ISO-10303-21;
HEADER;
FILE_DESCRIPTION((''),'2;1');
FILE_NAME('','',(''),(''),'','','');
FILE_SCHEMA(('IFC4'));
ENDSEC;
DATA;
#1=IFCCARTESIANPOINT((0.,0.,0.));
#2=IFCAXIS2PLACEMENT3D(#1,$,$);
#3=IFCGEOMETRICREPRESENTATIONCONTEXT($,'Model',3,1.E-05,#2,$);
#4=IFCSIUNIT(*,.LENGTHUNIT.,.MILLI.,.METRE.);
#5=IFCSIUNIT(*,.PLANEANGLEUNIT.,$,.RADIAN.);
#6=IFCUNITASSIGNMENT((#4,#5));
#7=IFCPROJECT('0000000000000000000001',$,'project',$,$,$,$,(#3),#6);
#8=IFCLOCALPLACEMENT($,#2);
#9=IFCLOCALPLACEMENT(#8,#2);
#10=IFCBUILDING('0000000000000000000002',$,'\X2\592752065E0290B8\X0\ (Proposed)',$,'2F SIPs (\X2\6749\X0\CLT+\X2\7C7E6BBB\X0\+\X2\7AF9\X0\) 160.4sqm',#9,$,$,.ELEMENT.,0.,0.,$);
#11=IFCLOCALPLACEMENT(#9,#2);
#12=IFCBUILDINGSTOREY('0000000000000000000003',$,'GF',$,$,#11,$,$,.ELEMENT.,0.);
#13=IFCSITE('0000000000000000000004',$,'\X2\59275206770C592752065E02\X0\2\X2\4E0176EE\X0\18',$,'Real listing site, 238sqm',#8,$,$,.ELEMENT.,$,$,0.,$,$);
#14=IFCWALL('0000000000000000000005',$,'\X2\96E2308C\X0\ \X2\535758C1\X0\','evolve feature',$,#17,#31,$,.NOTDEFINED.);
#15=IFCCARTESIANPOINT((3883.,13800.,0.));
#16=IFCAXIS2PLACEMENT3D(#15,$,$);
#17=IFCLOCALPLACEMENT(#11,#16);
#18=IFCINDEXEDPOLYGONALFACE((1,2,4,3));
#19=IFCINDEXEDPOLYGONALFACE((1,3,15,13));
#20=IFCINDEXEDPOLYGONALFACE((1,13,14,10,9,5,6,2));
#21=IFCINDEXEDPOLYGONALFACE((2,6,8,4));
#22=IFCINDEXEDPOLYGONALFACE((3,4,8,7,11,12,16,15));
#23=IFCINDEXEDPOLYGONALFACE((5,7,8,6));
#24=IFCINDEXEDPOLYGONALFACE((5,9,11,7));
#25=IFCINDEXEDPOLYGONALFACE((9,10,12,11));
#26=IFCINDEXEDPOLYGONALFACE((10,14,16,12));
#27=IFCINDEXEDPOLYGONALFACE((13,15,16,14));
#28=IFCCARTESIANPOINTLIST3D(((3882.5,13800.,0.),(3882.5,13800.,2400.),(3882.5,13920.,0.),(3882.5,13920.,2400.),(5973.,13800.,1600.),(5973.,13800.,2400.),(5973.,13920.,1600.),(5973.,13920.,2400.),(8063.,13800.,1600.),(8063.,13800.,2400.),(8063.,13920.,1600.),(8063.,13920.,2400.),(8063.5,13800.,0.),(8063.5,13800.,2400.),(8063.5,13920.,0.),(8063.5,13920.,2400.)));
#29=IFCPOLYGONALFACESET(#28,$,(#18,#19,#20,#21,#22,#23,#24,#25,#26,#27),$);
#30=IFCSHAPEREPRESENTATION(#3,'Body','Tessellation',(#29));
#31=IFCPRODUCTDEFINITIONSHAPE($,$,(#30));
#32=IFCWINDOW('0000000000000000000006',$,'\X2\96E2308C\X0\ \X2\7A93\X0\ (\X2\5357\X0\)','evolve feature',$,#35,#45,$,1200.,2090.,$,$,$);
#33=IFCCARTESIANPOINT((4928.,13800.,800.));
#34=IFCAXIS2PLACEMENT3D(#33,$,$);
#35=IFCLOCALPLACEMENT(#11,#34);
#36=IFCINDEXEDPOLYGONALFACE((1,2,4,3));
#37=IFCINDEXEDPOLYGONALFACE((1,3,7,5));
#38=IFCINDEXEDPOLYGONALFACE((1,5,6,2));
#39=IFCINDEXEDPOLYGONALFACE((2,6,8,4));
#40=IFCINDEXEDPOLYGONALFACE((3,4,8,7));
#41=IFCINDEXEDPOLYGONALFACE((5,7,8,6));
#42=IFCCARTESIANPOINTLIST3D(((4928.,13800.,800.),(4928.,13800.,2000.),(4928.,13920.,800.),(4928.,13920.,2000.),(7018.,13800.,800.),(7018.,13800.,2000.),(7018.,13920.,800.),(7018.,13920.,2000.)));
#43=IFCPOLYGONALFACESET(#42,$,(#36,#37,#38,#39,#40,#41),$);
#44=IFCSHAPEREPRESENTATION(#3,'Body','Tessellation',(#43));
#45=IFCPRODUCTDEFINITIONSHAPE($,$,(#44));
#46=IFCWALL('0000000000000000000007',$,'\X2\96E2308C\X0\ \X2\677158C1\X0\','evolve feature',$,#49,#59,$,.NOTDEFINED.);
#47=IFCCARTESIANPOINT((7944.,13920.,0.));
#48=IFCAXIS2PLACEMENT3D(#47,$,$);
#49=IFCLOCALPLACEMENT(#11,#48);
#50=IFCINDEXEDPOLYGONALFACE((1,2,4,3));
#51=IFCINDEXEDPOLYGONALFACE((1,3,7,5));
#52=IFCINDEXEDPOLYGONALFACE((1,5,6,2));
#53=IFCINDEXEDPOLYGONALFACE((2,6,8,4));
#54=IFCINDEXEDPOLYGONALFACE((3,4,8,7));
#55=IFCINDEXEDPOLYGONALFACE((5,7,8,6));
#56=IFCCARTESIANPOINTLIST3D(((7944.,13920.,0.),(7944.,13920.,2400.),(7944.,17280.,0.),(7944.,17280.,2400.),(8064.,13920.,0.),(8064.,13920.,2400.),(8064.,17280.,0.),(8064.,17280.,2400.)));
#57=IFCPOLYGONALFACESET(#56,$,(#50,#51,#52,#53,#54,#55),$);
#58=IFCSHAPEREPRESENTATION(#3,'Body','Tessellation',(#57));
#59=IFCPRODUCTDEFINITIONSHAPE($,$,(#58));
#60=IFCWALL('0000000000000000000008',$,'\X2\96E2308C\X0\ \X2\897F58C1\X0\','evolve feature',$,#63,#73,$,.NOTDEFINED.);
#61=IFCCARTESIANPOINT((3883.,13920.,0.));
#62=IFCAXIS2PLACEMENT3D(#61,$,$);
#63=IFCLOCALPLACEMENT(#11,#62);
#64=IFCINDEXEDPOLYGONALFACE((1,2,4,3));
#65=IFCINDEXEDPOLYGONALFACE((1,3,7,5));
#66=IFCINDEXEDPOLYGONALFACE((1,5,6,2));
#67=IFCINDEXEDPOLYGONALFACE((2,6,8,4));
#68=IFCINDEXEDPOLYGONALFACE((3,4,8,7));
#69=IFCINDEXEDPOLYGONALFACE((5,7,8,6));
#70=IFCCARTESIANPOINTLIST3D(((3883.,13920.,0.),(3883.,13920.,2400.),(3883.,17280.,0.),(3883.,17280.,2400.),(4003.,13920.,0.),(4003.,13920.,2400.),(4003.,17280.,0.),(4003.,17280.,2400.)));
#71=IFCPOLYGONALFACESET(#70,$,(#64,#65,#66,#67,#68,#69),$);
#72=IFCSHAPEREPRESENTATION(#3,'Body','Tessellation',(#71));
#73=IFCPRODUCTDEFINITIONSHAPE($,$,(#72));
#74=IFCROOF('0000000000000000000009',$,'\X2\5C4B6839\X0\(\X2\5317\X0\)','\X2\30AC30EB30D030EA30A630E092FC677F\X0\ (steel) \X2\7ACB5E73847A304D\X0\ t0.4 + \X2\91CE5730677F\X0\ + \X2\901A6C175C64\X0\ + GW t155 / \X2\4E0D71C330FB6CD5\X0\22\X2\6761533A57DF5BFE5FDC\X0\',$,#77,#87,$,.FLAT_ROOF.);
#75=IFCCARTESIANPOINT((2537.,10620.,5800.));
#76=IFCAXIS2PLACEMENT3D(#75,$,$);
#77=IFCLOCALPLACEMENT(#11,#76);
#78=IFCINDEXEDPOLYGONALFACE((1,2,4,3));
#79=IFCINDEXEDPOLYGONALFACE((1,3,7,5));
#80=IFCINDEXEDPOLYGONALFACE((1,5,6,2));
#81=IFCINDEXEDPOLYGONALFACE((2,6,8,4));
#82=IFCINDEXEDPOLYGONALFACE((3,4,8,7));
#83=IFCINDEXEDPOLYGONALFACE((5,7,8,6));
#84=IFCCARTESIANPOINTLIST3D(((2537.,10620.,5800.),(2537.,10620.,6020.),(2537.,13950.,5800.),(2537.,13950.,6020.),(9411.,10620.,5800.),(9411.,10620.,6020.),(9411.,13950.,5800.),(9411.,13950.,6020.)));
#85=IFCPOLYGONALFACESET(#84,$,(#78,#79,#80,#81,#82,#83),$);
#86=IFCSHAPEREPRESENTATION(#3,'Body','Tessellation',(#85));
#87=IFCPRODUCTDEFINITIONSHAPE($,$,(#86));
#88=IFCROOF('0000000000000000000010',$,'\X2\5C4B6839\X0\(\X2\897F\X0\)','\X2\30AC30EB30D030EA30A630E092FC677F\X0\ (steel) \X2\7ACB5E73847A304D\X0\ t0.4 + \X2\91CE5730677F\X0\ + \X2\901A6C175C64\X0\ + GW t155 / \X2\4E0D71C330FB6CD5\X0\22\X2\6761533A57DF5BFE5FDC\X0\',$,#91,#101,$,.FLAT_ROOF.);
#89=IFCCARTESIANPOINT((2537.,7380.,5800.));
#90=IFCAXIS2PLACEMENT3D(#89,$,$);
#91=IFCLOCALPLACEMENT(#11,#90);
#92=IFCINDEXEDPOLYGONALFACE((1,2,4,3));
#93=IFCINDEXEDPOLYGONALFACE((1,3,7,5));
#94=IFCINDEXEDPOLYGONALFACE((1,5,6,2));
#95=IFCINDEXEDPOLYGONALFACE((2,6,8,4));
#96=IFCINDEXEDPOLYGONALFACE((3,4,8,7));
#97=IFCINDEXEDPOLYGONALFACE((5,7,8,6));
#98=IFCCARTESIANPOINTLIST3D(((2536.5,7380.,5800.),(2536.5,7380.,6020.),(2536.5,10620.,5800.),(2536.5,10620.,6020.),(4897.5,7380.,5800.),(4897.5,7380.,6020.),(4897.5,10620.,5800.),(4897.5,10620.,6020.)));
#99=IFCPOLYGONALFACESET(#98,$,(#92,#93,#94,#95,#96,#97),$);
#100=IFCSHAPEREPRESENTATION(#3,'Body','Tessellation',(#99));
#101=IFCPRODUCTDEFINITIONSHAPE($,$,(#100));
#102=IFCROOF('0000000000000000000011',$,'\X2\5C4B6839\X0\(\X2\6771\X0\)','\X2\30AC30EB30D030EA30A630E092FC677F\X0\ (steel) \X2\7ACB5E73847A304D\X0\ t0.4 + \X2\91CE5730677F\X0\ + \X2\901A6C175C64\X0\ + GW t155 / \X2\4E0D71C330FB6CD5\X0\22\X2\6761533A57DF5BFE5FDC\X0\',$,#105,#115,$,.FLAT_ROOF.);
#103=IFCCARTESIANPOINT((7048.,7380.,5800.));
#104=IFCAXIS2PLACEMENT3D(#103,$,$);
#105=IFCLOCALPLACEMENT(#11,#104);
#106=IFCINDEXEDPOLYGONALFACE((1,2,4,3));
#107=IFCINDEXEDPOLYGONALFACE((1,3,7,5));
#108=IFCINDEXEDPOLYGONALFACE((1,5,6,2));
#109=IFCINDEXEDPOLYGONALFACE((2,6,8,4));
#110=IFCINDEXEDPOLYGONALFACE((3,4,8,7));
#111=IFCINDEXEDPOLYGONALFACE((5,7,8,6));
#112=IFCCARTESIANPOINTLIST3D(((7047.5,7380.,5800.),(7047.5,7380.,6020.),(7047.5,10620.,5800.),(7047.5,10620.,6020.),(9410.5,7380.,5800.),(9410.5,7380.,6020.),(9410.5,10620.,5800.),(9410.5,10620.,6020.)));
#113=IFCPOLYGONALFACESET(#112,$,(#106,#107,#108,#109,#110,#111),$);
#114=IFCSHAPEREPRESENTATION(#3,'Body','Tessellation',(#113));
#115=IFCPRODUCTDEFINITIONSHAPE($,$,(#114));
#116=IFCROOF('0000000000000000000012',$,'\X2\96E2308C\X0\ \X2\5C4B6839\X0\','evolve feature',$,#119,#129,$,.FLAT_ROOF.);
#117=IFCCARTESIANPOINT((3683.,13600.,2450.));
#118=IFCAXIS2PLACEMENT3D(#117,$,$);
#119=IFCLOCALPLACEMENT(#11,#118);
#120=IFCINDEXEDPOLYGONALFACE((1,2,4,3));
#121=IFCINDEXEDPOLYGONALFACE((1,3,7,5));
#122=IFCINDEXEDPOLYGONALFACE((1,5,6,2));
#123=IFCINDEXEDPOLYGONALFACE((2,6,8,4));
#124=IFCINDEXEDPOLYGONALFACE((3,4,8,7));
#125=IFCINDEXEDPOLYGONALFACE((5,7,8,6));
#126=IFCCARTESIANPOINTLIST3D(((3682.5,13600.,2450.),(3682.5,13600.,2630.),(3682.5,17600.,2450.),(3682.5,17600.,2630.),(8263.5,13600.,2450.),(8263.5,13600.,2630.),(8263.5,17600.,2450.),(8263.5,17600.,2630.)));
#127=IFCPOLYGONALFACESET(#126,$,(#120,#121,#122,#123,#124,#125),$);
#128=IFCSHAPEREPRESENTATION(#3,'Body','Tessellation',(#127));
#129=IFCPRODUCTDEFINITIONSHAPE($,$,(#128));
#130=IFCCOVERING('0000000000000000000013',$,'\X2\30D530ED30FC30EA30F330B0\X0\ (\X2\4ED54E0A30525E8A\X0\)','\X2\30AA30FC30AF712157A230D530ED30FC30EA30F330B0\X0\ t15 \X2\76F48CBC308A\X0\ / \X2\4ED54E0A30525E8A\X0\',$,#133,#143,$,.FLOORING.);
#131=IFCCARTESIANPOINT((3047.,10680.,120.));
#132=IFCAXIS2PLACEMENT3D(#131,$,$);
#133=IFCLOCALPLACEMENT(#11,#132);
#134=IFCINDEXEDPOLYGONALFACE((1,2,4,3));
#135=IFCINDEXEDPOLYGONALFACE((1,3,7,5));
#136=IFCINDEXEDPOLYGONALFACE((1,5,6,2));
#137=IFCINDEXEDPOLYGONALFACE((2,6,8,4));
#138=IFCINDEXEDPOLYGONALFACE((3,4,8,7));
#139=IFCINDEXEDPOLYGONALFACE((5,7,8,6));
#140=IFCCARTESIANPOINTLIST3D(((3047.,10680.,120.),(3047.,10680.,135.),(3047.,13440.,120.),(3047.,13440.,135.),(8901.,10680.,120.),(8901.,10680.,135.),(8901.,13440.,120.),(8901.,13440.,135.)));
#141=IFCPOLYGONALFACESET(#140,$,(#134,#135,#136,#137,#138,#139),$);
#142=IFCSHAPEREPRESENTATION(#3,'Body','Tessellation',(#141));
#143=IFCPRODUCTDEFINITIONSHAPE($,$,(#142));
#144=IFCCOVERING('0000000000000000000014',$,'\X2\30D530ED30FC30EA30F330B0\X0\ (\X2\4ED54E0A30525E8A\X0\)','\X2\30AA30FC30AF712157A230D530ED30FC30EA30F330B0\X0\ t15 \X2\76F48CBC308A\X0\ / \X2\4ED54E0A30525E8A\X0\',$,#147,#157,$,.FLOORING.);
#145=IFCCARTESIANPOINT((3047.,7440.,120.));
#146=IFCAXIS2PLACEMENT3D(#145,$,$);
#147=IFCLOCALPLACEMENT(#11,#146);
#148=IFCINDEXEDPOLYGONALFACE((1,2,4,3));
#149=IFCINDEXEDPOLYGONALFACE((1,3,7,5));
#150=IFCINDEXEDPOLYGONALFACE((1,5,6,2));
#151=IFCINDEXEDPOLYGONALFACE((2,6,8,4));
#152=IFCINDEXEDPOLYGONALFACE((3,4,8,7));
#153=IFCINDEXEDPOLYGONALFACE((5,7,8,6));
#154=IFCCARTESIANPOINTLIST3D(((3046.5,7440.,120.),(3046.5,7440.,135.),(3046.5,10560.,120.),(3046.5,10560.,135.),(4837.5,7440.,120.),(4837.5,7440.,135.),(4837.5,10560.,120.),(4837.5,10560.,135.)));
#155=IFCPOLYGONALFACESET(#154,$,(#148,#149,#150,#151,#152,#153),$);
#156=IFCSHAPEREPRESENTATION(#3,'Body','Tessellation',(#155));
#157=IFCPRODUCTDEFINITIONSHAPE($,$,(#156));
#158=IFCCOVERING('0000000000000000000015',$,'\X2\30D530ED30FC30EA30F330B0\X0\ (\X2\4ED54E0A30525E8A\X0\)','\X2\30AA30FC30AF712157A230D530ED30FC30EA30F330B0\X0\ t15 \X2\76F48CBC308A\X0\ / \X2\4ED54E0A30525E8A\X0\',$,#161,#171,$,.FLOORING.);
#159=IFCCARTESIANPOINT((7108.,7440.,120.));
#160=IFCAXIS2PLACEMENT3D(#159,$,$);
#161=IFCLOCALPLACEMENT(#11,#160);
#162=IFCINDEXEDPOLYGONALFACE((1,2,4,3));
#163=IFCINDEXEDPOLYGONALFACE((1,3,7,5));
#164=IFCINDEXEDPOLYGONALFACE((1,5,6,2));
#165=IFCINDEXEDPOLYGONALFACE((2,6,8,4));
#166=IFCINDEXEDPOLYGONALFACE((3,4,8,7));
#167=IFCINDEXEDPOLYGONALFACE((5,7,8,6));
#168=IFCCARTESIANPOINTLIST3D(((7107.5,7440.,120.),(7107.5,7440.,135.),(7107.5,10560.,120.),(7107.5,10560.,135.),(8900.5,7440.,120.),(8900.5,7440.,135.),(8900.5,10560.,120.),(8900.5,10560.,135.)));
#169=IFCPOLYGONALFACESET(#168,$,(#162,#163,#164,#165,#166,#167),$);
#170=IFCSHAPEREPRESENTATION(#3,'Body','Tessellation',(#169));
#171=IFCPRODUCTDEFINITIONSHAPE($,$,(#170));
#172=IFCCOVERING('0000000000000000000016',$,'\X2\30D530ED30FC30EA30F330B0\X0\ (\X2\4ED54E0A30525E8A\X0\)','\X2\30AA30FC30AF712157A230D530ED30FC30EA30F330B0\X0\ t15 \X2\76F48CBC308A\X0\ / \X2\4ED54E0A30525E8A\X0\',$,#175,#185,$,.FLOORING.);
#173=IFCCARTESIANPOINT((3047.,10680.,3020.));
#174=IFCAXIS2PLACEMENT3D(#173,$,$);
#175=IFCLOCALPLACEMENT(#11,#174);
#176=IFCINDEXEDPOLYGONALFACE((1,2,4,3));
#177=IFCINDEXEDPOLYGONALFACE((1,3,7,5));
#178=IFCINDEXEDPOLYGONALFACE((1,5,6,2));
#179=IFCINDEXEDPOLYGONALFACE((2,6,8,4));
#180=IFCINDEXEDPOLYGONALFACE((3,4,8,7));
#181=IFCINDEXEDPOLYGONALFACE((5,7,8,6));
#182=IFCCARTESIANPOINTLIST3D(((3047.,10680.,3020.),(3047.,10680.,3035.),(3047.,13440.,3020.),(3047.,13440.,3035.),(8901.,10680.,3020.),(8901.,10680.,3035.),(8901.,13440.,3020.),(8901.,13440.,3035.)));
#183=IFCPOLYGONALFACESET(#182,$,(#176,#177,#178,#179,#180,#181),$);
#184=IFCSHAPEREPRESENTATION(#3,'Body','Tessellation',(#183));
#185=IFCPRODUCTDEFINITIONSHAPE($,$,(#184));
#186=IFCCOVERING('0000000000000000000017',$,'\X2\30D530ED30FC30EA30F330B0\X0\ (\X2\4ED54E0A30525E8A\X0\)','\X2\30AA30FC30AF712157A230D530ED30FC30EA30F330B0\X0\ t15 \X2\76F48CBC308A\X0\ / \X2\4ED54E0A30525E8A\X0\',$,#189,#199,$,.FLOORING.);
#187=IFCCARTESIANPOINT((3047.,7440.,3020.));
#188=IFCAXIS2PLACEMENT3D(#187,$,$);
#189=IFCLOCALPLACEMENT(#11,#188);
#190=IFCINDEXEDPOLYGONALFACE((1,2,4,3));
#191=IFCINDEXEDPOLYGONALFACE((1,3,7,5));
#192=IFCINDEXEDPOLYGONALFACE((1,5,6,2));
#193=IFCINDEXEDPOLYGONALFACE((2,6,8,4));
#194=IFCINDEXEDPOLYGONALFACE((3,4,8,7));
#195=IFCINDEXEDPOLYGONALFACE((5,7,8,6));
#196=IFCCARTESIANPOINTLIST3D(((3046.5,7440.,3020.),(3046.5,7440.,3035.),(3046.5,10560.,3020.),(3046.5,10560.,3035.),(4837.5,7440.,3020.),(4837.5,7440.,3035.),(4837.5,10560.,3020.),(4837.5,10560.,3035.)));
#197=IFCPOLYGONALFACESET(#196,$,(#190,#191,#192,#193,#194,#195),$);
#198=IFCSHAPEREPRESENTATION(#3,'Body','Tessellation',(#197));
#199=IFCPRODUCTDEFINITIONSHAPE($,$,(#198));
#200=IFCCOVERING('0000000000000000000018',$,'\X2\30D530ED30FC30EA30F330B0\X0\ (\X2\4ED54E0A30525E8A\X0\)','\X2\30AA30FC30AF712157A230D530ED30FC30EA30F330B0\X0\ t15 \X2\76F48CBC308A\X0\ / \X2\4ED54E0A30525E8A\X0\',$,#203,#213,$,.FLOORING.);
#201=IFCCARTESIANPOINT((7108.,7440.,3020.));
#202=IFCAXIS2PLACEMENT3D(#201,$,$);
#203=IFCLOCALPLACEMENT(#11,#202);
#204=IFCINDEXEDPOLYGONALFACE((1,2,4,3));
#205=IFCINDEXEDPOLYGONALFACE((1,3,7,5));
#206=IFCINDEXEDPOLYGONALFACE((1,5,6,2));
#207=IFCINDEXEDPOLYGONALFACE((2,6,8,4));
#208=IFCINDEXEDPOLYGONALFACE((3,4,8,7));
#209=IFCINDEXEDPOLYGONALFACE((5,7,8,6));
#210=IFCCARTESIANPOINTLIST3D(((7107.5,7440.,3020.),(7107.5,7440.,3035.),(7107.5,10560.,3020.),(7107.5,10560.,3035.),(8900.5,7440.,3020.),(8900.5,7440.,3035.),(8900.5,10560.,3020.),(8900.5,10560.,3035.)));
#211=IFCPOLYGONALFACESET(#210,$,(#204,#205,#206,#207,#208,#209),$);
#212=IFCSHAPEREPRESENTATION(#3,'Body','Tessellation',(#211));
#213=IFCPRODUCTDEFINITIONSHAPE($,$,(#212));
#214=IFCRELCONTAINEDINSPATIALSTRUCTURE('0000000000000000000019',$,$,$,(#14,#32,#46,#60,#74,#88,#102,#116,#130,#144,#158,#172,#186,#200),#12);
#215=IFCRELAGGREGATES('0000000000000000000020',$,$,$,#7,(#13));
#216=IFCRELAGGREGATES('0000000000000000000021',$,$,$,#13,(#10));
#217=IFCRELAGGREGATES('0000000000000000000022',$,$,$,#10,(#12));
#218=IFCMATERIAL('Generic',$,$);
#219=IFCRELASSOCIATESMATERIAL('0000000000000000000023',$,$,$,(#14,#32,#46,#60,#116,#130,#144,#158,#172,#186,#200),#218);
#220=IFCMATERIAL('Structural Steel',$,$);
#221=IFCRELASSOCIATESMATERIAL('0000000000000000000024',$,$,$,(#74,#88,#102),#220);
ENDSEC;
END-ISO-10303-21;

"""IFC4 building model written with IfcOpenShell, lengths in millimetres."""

from ifc_helpers import new_model, si_unit, frame, frame_2d, origin, place, context, project, spatial, rectangle, extrude, material, element, fill, save


model = new_model("IFC4")

# Units and contexts
model_context = context("Model", 3, precision=1e-05, world=origin())
ifc_project = project(units=[si_unit("LENGTHUNIT", "METRE", prefix="MILLI"), si_unit("PLANEANGLEUNIT", "RADIAN")], contexts=[model_context])

# Site, building, storey
site_placement = place(None, origin())
site = spatial("IfcSite", under=ifc_project, at=site_placement, Name="大分県大分市2丁目18", ObjectType="Real listing site, 238sqm", CompositionType="ELEMENT", RefElevation=0.0)
building_placement = place(site_placement, origin())
building = spatial("IfcBuilding", under=site, at=building_placement, Name="大分市邸 (Proposed)", ObjectType="2F SIPs (杉CLT+籾殻+竹) 160.4sqm", CompositionType="ELEMENT", ElevationOfRefHeight=0.0, ElevationOfTerrain=0.0)
storey_placement = place(building_placement, origin())
storey = spatial("IfcBuildingStorey", under=building, at=storey_placement, Name="GF", CompositionType="ELEMENT", Elevation=0.0)

# Shared definitions
ifc_material_1 = material(Name="Generic")

# Wall, opening, window
wall_1_placement = place(storey_placement, frame((3883.0, 13800.0, 0.0)))
wall_1 = element("IfcWall", 1, at=wall_1_placement, inside=storey, material=ifc_material_1, Name="離れ 南壁", Description="evolve feature", PredefinedType="NOTDEFINED", context=model_context, shape_type="SweptSolid", body=[
    extrude(rectangle(XDim=4181.0, YDim=120.0, at=frame_2d((2090.0, 60.0))), frame((3883.0, 13800.0, 0.0)), (0.0, 0.0, 1.0), 2400.0),
])
opening_1_placement = place(storey_placement, frame((4928.0, 13800.0, 800.0)))
opening_1 = element("IfcOpeningElement", 2, at=opening_1_placement, cuts=wall_1, PredefinedType="NOTDEFINED", context=model_context, shape_type="SweptSolid", body=[
    extrude(rectangle(XDim=2090.0, YDim=120.0, at=frame_2d((1045.0, 60.0))), frame((4928.0, 13800.0, 800.0)), (0.0, 0.0, 1.0), 1200.0),
])
window_1_placement = place(storey_placement, frame((4928.0, 13800.0, 800.0)))
window_1 = element("IfcWindow", 3, at=window_1_placement, inside=storey, material=ifc_material_1, Name="離れ 窓 (南)", Description="evolve feature", OverallHeight=1200.0, OverallWidth=2090.0, context=model_context, shape_type="SweptSolid", body=[
    extrude(rectangle(XDim=2090.0, YDim=120.0, at=frame_2d((1045.0, 60.0))), frame((4928.0, 13800.0, 800.0)), (0.0, 0.0, 1.0), 1200.0),
])
fill(opening_1, window_1)

# Walls
wall_2_placement = place(storey_placement, frame((7944.0, 13920.0, 0.0)))
element("IfcWall", 4, at=wall_2_placement, inside=storey, material=ifc_material_1, Name="離れ 東壁", Description="evolve feature", PredefinedType="NOTDEFINED", context=model_context, shape_type="SweptSolid", body=[
    extrude(rectangle(XDim=120.0, YDim=3360.0, at=frame_2d((60.0, 1680.0))), frame((7944.0, 13920.0, 0.0)), (0.0, 0.0, 1.0), 2400.0),
])
wall_3_placement = place(storey_placement, frame((3883.0, 13920.0, 0.0)))
element("IfcWall", 5, at=wall_3_placement, inside=storey, material=ifc_material_1, Name="離れ 西壁", Description="evolve feature", PredefinedType="NOTDEFINED", context=model_context, shape_type="SweptSolid", body=[
    extrude(rectangle(XDim=120.0, YDim=3360.0, at=frame_2d((60.0, 1680.0))), frame((3883.0, 13920.0, 0.0)), (0.0, 0.0, 1.0), 2400.0),
])

# Roofs
ifc_material_2 = material(Name="Structural Steel")
for number, where, name in (
    (6, (2537.0, 10620.0, 5800.0), "屋根(北)"),
):
    element("IfcRoof", number, at=place(storey_placement, frame(where)), inside=storey, material=ifc_material_2, Name=name, Description="ガルバリウム鋼板 (steel) 立平葺き t0.4 + 野地板 + 通気層 + GW t155 / 不燃・法22条区域対応", PredefinedType="FLAT_ROOF", context=model_context, shape_type="SweptSolid", body=[
        extrude(rectangle(XDim=6874.0, YDim=3330.0, at=frame_2d((3437.0, 1665.0))), frame((2537.0, 10620.0, 5800.0)), (0.0, 0.0, 1.0), 220.0),
    ])
roof_1_placement = place(storey_placement, frame((2537.0, 7380.0, 5800.0)))
element("IfcRoof", 7, at=roof_1_placement, inside=storey, material=ifc_material_2, Name="屋根(西)", Description="ガルバリウム鋼板 (steel) 立平葺き t0.4 + 野地板 + 通気層 + GW t155 / 不燃・法22条区域対応", PredefinedType="FLAT_ROOF", context=model_context, shape_type="SweptSolid", body=[
    extrude(rectangle(XDim=2361.0, YDim=3240.0, at=frame_2d((1180.0, 1620.0))), frame((2537.0, 7380.0, 5800.0)), (0.0, 0.0, 1.0), 220.0),
])
roof_2_placement = place(storey_placement, frame((7048.0, 7380.0, 5800.0)))
element("IfcRoof", 8, at=roof_2_placement, inside=storey, material=ifc_material_2, Name="屋根(東)", Description="ガルバリウム鋼板 (steel) 立平葺き t0.4 + 野地板 + 通気層 + GW t155 / 不燃・法22条区域対応", PredefinedType="FLAT_ROOF", context=model_context, shape_type="SweptSolid", body=[
    extrude(rectangle(XDim=2363.0, YDim=3240.0, at=frame_2d((1181.0, 1620.0))), frame((7048.0, 7380.0, 5800.0)), (0.0, 0.0, 1.0), 220.0),
])
roof_3_placement = place(storey_placement, frame((3683.0, 13600.0, 2450.0)))
element("IfcRoof", 9, at=roof_3_placement, inside=storey, material=ifc_material_1, Name="離れ 屋根", Description="evolve feature", PredefinedType="FLAT_ROOF", context=model_context, shape_type="SweptSolid", body=[
    extrude(rectangle(XDim=4581.0, YDim=4000.0, at=frame_2d((2290.0, 2000.0))), frame((3683.0, 13600.0, 2450.0)), (0.0, 0.0, 1.0), 180.0),
])

# Coverings
covering_1_placement = place(storey_placement, frame((3047.0, 10680.0, 120.0)))
element("IfcCovering", 10, at=covering_1_placement, inside=storey, material=ifc_material_1, Name="フローリング (仕上げ床)", Description="オーク無垢フローリング t15 直貼り / 仕上げ床", PredefinedType="FLOORING", context=model_context, shape_type="SweptSolid", body=[
    extrude(rectangle(XDim=5854.0, YDim=2760.0, at=frame_2d((2927.0, 1380.0))), frame((3047.0, 10680.0, 120.0)), (0.0, 0.0, 1.0), 15.0),
])
covering_2_placement = place(storey_placement, frame((3047.0, 7440.0, 120.0)))
element("IfcCovering", 11, at=covering_2_placement, inside=storey, material=ifc_material_1, Name="フローリング (仕上げ床)", Description="オーク無垢フローリング t15 直貼り / 仕上げ床", PredefinedType="FLOORING", context=model_context, shape_type="SweptSolid", body=[
    extrude(rectangle(XDim=1791.0, YDim=3120.0, at=frame_2d((895.0, 1560.0))), frame((3047.0, 7440.0, 120.0)), (0.0, 0.0, 1.0), 15.0),
])
covering_3_placement = place(storey_placement, frame((7108.0, 7440.0, 120.0)))
element("IfcCovering", 12, at=covering_3_placement, inside=storey, material=ifc_material_1, Name="フローリング (仕上げ床)", Description="オーク無垢フローリング t15 直貼り / 仕上げ床", PredefinedType="FLOORING", context=model_context, shape_type="SweptSolid", body=[
    extrude(rectangle(XDim=1793.0, YDim=3120.0, at=frame_2d((896.0, 1560.0))), frame((7108.0, 7440.0, 120.0)), (0.0, 0.0, 1.0), 15.0),
])
covering_4_placement = place(storey_placement, frame((3047.0, 10680.0, 3020.0)))
element("IfcCovering", 13, at=covering_4_placement, inside=storey, material=ifc_material_1, Name="フローリング (仕上げ床)", Description="オーク無垢フローリング t15 直貼り / 仕上げ床", PredefinedType="FLOORING", context=model_context, shape_type="SweptSolid", body=[
    extrude(rectangle(XDim=5854.0, YDim=2760.0, at=frame_2d((2927.0, 1380.0))), frame((3047.0, 10680.0, 3020.0)), (0.0, 0.0, 1.0), 15.0),
])
covering_5_placement = place(storey_placement, frame((3047.0, 7440.0, 3020.0)))
element("IfcCovering", 14, at=covering_5_placement, inside=storey, material=ifc_material_1, Name="フローリング (仕上げ床)", Description="オーク無垢フローリング t15 直貼り / 仕上げ床", PredefinedType="FLOORING", context=model_context, shape_type="SweptSolid", body=[
    extrude(rectangle(XDim=1791.0, YDim=3120.0, at=frame_2d((895.0, 1560.0))), frame((3047.0, 7440.0, 3020.0)), (0.0, 0.0, 1.0), 15.0),
])
covering_6_placement = place(storey_placement, frame((7108.0, 7440.0, 3020.0)))
element("IfcCovering", 15, at=covering_6_placement, inside=storey, material=ifc_material_1, Name="フローリング (仕上げ床)", Description="オーク無垢フローリング t15 直貼り / 仕上げ床", PredefinedType="FLOORING", context=model_context, shape_type="SweptSolid", body=[
    extrude(rectangle(XDim=1793.0, YDim=3120.0, at=frame_2d((896.0, 1560.0))), frame((7108.0, 7440.0, 3020.0)), (0.0, 0.0, 1.0), 15.0),
])

save(model, "model.ifc")
